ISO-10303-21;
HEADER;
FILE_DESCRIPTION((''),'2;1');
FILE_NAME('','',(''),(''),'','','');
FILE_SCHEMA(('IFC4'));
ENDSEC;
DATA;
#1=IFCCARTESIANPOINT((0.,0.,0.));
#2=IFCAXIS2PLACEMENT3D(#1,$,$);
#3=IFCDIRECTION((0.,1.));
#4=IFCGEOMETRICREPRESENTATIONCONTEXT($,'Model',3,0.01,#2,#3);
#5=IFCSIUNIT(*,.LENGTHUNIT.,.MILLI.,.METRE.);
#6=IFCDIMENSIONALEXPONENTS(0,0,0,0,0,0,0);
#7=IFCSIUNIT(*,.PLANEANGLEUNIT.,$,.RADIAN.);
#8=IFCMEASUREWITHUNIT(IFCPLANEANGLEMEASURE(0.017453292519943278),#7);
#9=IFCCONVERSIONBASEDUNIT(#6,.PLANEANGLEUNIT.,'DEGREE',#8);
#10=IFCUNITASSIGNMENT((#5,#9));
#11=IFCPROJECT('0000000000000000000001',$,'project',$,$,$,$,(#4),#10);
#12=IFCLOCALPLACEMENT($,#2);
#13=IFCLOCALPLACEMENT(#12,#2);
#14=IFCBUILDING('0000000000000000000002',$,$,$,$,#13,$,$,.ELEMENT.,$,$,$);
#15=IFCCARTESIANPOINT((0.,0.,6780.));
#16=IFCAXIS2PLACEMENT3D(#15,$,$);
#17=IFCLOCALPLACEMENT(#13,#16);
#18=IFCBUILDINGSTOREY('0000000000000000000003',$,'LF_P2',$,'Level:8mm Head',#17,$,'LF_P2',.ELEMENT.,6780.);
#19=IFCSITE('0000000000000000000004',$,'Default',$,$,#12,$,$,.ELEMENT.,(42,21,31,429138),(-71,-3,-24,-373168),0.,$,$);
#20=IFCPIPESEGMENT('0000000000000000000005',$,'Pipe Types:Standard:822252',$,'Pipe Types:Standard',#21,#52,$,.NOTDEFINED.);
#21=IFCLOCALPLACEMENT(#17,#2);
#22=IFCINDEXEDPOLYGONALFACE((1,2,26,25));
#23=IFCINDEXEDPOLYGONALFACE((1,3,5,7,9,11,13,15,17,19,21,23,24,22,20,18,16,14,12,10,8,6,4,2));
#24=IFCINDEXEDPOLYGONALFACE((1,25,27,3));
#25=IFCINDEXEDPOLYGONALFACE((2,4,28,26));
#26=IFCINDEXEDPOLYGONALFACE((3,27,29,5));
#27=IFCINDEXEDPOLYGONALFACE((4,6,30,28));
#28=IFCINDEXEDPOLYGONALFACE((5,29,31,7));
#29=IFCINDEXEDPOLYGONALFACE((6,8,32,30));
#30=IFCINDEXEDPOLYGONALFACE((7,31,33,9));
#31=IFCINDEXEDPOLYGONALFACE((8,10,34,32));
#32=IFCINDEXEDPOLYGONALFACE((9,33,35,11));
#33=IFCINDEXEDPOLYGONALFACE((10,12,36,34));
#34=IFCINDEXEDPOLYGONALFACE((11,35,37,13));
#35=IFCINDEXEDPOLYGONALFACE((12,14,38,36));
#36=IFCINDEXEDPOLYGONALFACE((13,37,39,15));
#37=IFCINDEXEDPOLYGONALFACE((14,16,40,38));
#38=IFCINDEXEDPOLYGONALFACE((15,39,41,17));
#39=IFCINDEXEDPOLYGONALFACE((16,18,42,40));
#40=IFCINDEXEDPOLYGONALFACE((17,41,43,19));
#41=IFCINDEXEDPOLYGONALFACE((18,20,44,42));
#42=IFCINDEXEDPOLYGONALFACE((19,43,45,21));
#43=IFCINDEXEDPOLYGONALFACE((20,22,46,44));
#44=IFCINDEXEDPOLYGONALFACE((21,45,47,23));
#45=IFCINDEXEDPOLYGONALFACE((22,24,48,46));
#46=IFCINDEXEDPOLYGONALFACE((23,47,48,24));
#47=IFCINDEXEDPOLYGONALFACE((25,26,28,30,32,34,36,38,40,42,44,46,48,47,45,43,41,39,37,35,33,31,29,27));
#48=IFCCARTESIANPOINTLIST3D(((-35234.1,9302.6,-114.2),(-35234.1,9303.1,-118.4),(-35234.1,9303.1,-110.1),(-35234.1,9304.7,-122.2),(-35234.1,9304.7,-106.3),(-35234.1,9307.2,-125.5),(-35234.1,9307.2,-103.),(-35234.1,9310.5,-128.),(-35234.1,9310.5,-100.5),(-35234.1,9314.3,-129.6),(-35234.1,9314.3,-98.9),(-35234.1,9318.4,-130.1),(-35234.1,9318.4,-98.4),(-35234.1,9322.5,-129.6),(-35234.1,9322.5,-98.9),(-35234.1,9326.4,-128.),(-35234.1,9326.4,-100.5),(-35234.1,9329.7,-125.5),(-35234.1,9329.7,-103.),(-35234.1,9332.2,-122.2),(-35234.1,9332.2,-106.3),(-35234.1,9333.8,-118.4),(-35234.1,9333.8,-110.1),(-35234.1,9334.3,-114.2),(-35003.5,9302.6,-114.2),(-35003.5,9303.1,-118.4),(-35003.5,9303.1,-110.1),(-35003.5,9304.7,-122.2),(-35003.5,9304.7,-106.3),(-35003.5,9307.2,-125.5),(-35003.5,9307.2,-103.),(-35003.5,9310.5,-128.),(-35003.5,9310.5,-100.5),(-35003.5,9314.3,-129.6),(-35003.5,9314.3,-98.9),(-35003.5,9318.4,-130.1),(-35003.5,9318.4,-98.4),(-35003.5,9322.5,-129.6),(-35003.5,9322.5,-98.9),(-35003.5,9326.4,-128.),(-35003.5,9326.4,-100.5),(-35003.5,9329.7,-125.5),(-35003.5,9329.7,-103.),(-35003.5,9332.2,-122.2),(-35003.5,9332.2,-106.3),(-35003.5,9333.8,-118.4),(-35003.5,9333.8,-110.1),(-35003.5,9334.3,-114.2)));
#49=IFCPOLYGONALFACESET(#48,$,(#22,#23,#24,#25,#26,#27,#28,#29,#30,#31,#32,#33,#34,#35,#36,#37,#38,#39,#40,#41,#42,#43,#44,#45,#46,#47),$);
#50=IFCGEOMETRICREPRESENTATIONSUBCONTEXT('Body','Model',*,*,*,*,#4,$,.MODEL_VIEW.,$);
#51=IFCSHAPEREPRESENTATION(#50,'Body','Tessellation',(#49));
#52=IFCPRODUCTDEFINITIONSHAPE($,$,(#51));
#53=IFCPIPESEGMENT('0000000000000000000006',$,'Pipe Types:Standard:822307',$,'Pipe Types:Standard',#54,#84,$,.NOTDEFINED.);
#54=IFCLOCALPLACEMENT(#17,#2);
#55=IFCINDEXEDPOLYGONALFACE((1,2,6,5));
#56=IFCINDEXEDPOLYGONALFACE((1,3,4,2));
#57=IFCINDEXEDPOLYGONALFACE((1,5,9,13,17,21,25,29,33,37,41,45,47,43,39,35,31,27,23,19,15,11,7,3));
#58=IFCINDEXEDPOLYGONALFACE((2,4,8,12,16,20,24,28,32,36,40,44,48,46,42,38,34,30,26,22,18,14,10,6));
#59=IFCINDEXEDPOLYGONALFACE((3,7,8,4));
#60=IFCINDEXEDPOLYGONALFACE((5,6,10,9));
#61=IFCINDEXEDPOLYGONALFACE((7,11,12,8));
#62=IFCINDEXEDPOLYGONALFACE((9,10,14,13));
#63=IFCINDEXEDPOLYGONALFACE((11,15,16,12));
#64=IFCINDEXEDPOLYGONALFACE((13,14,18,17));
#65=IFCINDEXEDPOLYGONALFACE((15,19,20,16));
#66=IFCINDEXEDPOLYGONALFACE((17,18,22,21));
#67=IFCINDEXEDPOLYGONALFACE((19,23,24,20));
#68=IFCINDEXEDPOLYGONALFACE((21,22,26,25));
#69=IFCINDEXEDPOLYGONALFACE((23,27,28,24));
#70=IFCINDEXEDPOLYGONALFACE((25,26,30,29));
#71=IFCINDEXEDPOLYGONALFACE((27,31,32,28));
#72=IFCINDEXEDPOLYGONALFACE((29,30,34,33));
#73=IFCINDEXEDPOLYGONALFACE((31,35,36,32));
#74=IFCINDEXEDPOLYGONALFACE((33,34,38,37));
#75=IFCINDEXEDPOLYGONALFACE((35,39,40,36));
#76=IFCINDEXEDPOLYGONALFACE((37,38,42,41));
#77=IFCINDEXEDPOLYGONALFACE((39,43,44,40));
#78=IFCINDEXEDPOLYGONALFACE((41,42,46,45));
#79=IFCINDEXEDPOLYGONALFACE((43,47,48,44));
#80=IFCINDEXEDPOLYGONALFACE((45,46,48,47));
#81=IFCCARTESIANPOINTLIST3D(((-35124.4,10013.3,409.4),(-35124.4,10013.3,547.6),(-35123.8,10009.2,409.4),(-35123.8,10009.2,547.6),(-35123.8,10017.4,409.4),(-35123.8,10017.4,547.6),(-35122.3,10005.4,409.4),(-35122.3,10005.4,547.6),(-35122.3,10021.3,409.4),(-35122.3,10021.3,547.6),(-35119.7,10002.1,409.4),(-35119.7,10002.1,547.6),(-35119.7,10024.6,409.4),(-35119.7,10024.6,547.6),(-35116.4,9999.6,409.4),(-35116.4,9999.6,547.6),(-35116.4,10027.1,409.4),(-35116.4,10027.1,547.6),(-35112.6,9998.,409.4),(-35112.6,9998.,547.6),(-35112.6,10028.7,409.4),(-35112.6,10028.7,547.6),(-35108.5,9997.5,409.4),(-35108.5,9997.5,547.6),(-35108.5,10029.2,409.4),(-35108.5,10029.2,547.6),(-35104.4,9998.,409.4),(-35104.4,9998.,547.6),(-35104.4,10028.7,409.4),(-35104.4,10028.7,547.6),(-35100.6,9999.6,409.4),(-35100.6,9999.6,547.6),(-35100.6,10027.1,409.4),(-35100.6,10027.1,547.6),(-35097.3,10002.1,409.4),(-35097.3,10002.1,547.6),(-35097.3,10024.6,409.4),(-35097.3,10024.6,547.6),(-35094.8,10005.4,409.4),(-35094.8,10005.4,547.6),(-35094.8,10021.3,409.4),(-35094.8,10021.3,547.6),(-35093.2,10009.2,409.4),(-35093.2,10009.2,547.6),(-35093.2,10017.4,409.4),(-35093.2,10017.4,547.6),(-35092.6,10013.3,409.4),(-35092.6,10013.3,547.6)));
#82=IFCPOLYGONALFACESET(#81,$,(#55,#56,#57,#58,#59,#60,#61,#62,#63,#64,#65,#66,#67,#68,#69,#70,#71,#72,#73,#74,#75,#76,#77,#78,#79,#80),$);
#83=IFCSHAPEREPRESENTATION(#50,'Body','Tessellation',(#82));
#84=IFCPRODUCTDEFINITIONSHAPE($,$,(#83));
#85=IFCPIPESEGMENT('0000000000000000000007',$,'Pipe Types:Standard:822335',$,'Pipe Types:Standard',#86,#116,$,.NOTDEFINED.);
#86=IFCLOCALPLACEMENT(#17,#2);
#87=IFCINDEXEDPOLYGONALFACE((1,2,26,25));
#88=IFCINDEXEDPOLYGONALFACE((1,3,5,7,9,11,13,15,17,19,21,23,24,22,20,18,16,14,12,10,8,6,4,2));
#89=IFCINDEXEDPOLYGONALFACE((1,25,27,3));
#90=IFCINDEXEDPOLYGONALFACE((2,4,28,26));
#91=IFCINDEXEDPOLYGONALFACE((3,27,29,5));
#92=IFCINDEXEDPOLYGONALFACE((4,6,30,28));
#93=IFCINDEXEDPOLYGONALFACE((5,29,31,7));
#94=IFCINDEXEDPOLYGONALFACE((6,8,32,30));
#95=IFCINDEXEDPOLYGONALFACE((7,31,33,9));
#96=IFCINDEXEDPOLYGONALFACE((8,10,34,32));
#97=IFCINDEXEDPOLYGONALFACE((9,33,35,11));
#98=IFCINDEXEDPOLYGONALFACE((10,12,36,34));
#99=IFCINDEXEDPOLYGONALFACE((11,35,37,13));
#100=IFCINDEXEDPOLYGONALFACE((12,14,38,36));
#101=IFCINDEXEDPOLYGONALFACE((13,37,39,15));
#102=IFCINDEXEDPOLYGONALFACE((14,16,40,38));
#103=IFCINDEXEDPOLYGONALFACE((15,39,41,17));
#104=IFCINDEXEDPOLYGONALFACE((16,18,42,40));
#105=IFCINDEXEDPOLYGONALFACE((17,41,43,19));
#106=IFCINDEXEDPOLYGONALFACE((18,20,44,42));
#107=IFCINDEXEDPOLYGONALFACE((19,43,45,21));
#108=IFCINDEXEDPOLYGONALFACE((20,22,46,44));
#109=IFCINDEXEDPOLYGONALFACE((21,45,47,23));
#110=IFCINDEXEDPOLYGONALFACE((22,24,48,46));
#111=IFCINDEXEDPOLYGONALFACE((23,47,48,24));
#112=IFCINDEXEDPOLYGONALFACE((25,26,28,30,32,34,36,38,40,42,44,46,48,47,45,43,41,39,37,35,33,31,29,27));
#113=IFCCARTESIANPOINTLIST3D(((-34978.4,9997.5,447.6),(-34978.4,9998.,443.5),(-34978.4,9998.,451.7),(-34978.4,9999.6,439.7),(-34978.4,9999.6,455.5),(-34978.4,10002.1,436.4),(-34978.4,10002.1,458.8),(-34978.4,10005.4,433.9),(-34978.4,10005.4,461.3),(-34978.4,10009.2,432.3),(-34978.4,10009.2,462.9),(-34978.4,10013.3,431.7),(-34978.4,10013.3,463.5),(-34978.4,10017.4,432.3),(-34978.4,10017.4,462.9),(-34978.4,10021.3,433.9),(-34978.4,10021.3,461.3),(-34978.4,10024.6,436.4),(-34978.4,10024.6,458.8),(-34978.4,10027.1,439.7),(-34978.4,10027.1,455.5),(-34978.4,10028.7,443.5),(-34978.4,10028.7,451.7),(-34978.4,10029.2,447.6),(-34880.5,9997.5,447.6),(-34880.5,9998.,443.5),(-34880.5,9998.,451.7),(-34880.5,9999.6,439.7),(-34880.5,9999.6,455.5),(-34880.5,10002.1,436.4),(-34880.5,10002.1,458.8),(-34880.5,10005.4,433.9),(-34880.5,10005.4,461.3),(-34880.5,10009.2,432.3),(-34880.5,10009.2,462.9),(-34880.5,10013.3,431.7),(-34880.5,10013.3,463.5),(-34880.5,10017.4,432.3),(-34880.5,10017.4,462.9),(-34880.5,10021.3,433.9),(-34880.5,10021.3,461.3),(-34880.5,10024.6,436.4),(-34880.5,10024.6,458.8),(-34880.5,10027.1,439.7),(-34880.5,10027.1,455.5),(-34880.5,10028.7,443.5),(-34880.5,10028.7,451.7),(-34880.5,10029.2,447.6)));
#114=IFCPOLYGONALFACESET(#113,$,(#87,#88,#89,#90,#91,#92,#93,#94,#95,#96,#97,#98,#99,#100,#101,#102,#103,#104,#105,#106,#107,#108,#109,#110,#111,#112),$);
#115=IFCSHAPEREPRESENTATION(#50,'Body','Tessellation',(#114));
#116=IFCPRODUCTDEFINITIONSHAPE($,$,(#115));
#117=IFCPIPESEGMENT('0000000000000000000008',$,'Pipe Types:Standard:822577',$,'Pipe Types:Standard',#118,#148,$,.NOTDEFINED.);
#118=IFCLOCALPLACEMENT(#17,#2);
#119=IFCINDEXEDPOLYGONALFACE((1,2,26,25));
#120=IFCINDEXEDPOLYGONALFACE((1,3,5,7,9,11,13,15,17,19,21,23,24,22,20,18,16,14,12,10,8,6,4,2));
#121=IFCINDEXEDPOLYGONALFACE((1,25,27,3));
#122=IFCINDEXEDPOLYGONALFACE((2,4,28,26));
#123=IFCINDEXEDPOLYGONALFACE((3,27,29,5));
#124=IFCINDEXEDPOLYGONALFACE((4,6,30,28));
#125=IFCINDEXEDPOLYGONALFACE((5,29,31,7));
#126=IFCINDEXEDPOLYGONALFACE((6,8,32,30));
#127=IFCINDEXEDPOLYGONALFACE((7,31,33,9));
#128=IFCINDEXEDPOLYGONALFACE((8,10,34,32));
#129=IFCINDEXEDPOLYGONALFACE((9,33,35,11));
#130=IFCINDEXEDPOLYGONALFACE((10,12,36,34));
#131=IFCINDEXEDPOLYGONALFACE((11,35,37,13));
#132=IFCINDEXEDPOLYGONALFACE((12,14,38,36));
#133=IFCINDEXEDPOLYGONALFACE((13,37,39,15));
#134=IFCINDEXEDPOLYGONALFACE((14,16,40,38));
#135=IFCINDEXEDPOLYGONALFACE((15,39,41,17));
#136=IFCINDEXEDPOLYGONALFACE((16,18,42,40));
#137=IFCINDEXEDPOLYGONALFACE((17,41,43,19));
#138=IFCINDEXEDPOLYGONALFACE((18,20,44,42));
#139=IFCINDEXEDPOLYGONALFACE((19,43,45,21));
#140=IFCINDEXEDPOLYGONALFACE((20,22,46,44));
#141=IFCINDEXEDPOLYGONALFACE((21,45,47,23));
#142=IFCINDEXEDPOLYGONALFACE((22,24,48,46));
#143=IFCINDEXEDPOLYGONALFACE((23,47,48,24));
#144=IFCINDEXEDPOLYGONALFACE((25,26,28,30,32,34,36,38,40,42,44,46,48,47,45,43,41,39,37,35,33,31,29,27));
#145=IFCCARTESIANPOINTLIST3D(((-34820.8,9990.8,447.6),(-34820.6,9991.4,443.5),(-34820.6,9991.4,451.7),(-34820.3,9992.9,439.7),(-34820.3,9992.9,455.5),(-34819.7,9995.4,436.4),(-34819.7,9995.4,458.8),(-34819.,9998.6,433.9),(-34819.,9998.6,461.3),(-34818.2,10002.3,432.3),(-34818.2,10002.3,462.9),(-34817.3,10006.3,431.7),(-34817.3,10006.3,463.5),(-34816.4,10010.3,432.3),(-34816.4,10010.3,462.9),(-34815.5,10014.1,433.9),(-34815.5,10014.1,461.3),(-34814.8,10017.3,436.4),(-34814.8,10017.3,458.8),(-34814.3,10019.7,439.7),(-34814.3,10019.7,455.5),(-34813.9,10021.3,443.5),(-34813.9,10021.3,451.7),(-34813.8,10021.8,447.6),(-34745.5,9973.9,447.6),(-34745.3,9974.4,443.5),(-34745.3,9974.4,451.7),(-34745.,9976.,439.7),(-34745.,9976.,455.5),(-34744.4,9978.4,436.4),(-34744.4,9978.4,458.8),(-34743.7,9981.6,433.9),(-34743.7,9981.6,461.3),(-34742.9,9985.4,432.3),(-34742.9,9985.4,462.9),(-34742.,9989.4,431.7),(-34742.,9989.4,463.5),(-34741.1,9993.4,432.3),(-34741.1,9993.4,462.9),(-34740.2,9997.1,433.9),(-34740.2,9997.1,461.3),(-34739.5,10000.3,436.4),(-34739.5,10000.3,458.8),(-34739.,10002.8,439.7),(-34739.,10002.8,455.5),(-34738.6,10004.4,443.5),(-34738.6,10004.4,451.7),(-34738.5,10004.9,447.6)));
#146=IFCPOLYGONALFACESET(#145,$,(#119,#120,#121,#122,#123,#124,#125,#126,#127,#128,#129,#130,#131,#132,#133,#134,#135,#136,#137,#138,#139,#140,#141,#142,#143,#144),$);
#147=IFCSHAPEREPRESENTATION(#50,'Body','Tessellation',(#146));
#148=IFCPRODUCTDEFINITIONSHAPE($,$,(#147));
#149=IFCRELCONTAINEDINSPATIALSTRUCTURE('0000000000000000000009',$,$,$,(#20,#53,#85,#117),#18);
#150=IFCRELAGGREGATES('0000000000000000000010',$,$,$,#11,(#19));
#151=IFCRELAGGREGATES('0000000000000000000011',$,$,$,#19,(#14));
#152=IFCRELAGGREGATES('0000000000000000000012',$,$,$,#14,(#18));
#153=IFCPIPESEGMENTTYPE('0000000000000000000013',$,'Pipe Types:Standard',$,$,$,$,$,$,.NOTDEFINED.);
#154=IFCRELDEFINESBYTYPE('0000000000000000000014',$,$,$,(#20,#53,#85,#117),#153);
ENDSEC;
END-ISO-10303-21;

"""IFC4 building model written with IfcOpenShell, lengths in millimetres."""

from ifc_helpers import new_model, entity, si_unit, converted_unit, direction, frame, origin, place, context, subcontext, project, spatial, arc, indexed_curve, outline, extrude, type_object, element, save


model = new_model("IFC4")

# Units and contexts
model_context = context("Model", 3, precision=0.01, world=origin(), true_north=direction((0.0, 1.0)))
body_context = subcontext(model_context, "Body", "Model", "MODEL_VIEW")
ifc_project = project(units=[si_unit("LENGTHUNIT", "METRE", prefix="MILLI"), converted_unit("PLANEANGLEUNIT", "DEGREE", entity("IfcPlaneAngleMeasure", 0.017453292519943278), si_unit("PLANEANGLEUNIT", "RADIAN"), dimensions=[0, 0, 0, 0, 0, 0, 0])], contexts=[model_context])

# Site, building, storey
site_placement = place(None, origin())
site = spatial("IfcSite", under=ifc_project, at=site_placement, Name="Default", CompositionType="ELEMENT", RefLatitude=(42, 21, 31, 429138), RefLongitude=(-71, -3, -24, -373168), RefElevation=0.0)
building_placement = place(site_placement, origin())
building = spatial("IfcBuilding", under=site, at=building_placement, CompositionType="ELEMENT")
storey_placement = place(building_placement, frame((0.0, 0.0, 6780.0)))
storey = spatial("IfcBuildingStorey", under=building, at=storey_placement, Name="LF_P2", ObjectType="Level:8mm Head", LongName="LF_P2", CompositionType="ELEMENT", Elevation=6780.0)

# Pipe segments
pipe_segment_type_1 = type_object("IfcPipeSegmentType", Name="Pipe Types:Standard", PredefinedType="NOTDEFINED")
pipe_segment_1_placement = place(storey_placement, origin())
element("IfcPipeSegment", 1, at=pipe_segment_1_placement, inside=storey, type_object=pipe_segment_type_1, Name="Pipe Types:Standard:822252", ObjectType="Pipe Types:Standard", PredefinedType="NOTDEFINED", context=body_context, shape_type="SweptSolid", body=[
    extrude(outline(indexed_curve([(15.9, 0.0), (11.2, 11.2), (0.0, 15.9), (-11.2, 11.2), (-15.9, 0.0), (-11.2, -11.2), (0.0, -15.9), (11.2, -11.2)], segments=[arc(1, 2, 3), arc(3, 4, 5), arc(5, 6, 7), arc(7, 8, 1)], self_intersect=False)), frame((-35234.1, 9318.4, -114.2), z_axis=(1.0, 0.0, 0.0), x_axis=(0.0, 1.0, 0.0)), (0.0, 0.0, 1.0), 230.6),
])
pipe_segment_2_placement = place(storey_placement, origin())
element("IfcPipeSegment", 2, at=pipe_segment_2_placement, inside=storey, type_object=pipe_segment_type_1, Name="Pipe Types:Standard:822307", ObjectType="Pipe Types:Standard", PredefinedType="NOTDEFINED", context=body_context, shape_type="SweptSolid", body=[
    extrude(outline(indexed_curve([(15.9, 0.0), (11.2, 11.2), (0.0, 15.9), (-11.2, 11.2), (-15.9, 0.0), (-11.2, -11.2), (0.0, -15.9), (11.2, -11.2)], segments=[arc(1, 2, 3), arc(3, 4, 5), arc(5, 6, 7), arc(7, 8, 1)], self_intersect=False)), frame((-35108.5, 10013.3, 409.4)), (0.0, 0.0, 1.0), 138.2),
])
pipe_segment_3_placement = place(storey_placement, origin())
element("IfcPipeSegment", 3, at=pipe_segment_3_placement, inside=storey, type_object=pipe_segment_type_1, Name="Pipe Types:Standard:822335", ObjectType="Pipe Types:Standard", PredefinedType="NOTDEFINED", context=body_context, shape_type="SweptSolid", body=[
    extrude(outline(indexed_curve([(15.9, 0.0), (11.2, 11.2), (0.0, 15.9), (-11.2, 11.2), (-15.9, 0.0), (-11.2, -11.2), (0.0, -15.9), (11.2, -11.2)], segments=[arc(1, 2, 3), arc(3, 4, 5), arc(5, 6, 7), arc(7, 8, 1)], self_intersect=False)), frame((-34978.4, 10013.3, 447.6), z_axis=(1.0, 0.0, 0.0), x_axis=(0.0, 1.0, 0.0)), (0.0, 0.0, 1.0), 97.9),
])
pipe_segment_4_placement = place(storey_placement, origin())
element("IfcPipeSegment", 4, at=pipe_segment_4_placement, inside=storey, type_object=pipe_segment_type_1, Name="Pipe Types:Standard:822577", ObjectType="Pipe Types:Standard", PredefinedType="NOTDEFINED", context=body_context, shape_type="SweptSolid", body=[
    extrude(outline(indexed_curve([(15.9, 0.0), (11.2, 11.2), (0.0, 15.9), (-11.2, 11.2), (-15.9, 0.0), (-11.2, -11.2), (0.0, -15.9), (11.2, -11.2)], segments=[arc(1, 2, 3), arc(3, 4, 5), arc(5, 6, 7), arc(7, 8, 1)], self_intersect=False)), frame((-34817.3, 10006.3, 447.6), z_axis=(0.975672, -0.219233, 0.0), x_axis=(0.219233, 0.975672, 0.0)), (0.0, 0.0, 1.0), 77.2),
])

save(model, "model.ifc")
